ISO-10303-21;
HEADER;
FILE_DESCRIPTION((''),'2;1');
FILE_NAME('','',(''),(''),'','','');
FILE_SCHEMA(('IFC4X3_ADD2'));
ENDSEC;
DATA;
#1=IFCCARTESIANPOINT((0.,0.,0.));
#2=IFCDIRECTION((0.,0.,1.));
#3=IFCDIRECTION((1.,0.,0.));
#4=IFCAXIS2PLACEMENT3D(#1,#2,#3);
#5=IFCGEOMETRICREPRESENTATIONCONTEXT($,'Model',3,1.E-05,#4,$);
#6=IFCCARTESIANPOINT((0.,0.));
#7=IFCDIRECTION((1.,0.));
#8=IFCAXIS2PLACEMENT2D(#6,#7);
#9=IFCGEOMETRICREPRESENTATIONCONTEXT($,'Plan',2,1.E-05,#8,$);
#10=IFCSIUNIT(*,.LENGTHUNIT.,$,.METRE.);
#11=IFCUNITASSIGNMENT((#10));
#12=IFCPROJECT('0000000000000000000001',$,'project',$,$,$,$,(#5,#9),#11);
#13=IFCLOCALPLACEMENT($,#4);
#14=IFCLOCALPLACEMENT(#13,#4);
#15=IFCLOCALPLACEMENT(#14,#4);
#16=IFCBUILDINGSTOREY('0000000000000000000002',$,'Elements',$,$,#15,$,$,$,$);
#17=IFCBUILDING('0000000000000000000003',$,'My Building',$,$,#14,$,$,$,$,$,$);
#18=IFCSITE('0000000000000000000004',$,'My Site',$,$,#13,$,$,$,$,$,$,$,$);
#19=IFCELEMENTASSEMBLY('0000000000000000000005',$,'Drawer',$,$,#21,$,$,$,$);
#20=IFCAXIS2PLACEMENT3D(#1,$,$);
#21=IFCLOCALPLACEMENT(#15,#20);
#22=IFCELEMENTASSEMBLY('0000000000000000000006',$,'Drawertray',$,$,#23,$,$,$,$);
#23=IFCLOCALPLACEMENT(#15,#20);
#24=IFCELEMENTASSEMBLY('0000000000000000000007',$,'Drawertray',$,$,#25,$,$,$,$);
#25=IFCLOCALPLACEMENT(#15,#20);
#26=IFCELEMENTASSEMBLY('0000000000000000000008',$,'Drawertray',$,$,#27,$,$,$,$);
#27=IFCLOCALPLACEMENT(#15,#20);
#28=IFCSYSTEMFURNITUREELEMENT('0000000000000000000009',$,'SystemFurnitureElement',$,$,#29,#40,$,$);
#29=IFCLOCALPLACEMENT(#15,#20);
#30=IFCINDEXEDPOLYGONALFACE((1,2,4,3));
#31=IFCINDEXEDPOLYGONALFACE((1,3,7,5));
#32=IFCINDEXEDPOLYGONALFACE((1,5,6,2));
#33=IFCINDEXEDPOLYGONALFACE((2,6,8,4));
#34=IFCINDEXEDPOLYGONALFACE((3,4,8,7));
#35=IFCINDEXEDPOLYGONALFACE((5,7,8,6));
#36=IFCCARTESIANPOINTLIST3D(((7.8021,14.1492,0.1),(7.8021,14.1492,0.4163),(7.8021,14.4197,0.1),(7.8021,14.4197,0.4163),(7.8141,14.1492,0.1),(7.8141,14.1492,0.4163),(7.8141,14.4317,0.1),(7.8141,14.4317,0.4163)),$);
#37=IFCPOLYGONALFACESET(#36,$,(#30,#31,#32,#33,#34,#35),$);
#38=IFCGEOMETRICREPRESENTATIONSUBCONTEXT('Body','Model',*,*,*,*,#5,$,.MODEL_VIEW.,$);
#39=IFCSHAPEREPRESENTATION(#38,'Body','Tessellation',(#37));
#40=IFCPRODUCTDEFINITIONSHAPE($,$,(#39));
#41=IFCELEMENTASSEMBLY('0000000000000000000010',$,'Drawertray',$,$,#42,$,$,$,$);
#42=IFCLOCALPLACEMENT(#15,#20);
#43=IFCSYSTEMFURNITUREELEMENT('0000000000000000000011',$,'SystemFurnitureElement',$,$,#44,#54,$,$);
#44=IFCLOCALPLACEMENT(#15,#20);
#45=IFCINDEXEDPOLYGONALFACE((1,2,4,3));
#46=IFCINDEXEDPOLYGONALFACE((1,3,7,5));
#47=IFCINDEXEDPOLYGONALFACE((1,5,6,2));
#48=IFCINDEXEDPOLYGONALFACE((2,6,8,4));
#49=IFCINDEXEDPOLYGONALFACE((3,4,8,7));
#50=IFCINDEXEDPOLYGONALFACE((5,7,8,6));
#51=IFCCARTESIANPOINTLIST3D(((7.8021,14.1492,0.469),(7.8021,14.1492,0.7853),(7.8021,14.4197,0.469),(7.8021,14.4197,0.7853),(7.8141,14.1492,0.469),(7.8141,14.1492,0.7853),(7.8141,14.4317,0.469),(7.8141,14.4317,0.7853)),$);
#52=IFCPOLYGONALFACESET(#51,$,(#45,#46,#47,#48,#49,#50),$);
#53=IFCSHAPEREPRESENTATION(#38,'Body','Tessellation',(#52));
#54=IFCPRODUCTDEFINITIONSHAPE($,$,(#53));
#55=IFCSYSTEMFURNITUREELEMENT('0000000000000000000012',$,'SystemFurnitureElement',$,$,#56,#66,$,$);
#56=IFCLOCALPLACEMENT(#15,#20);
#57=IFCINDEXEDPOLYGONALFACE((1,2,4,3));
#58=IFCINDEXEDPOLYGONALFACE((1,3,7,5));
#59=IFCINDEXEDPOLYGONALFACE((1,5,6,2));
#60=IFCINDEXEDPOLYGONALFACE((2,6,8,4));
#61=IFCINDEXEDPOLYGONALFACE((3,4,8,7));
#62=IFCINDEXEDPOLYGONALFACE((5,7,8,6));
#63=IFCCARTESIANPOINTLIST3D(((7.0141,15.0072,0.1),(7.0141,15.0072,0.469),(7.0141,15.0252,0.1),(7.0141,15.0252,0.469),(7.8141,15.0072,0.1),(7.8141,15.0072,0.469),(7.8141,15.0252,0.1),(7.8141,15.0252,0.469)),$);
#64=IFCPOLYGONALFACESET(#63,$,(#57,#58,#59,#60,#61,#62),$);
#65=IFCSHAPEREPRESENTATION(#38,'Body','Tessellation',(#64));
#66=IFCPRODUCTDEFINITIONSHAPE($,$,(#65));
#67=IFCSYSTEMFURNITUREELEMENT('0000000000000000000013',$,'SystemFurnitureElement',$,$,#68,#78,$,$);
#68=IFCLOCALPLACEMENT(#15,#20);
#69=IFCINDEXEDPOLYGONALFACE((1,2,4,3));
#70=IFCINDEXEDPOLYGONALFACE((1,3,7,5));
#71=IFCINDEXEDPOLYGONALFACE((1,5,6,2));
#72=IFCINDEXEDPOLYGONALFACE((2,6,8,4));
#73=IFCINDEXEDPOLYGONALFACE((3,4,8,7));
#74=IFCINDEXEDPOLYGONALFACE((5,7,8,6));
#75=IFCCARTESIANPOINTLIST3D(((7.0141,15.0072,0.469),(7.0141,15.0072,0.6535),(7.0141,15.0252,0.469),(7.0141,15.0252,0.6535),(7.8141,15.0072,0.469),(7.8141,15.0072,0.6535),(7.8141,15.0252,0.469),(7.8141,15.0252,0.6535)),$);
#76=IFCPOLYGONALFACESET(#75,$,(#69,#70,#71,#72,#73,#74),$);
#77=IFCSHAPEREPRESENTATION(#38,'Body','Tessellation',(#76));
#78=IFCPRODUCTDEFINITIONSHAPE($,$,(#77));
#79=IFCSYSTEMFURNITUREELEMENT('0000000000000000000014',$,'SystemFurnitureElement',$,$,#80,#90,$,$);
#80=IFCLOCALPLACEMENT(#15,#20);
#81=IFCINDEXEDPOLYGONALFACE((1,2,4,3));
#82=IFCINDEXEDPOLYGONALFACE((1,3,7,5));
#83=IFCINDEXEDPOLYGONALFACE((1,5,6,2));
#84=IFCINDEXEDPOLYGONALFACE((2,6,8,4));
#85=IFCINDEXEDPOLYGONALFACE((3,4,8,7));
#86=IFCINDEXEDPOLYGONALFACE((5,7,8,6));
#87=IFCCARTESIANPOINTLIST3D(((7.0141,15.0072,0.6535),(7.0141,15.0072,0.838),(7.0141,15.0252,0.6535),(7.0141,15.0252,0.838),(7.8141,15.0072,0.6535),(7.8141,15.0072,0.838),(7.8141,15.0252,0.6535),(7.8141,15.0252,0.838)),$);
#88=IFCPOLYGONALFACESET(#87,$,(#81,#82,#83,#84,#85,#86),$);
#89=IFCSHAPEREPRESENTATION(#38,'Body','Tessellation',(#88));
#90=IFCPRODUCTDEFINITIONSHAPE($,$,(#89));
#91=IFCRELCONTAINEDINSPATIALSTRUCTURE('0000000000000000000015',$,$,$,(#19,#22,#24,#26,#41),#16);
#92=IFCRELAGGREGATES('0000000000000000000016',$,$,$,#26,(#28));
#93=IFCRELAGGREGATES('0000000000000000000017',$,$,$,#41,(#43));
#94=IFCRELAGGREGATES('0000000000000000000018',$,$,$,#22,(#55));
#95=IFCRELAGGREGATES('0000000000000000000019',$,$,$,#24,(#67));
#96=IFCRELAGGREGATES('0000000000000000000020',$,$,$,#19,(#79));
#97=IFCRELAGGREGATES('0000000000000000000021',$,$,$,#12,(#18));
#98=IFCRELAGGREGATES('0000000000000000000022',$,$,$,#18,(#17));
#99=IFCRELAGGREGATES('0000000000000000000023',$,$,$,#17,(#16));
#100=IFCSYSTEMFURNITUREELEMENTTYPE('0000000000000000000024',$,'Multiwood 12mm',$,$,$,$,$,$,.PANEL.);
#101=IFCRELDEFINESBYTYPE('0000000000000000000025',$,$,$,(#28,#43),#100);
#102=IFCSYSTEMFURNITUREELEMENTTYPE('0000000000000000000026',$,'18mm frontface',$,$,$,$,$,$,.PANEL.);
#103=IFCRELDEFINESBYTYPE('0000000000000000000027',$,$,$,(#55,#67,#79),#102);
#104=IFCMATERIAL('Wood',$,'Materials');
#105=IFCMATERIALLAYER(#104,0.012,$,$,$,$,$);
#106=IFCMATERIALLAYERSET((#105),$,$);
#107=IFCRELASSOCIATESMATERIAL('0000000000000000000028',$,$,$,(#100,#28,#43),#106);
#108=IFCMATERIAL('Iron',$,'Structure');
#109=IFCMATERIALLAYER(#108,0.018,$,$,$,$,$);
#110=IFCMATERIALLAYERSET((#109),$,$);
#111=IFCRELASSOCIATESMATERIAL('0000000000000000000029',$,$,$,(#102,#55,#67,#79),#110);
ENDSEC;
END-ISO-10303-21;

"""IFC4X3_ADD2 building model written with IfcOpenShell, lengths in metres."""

from ifc_helpers import new_model, si_unit, frame, origin_with_axes, origin_2d_with_axis, place, context, subcontext, project, spatial, line, indexed_curve, outline, extrude, material, layer, layer_set, layer_usage, type_object, element, aggregate, save


model = new_model("IFC4X3_ADD2")

# Units and contexts
model_context = context("Model", 3, precision=1e-05, world=origin_with_axes())
plan_context = context("Plan", 2, precision=1e-05, world=origin_2d_with_axis())
body_context = subcontext(model_context, "Body", "Model", "MODEL_VIEW")
ifc_project = project(units=[si_unit("LENGTHUNIT", "METRE")], contexts=[model_context, plan_context])

# Site, building, storey
site_placement = place(None, origin_with_axes())
site = spatial("IfcSite", under=ifc_project, at=site_placement, Name="My Site")
building_placement = place(site_placement, origin_with_axes())
building = spatial("IfcBuilding", under=site, at=building_placement, Name="My Building")
storey_placement = place(building_placement, origin_with_axes())
storey = spatial("IfcBuildingStorey", under=building, at=storey_placement, Name="Elements")

# Shared definitions
ifc_material_1 = material(Name="Wood", Category="Materials")
ifc_layer_1 = layer(ifc_material_1, 0.012)
ifc_layer_set_1 = layer_set([ifc_layer_1])
system_furniture_element_type_1 = type_object("IfcSystemFurnitureElementType", Name="Multiwood 12mm", PredefinedType="PANEL", material=ifc_layer_set_1)

# Element assemblies
assembly_1_placement = place(storey_placement, frame((7.8141, 15.0252, 0.6535), z_axis=(0.0, 0.0, 1.0), x_axis=(1.0, 0.0, 0.0)))
assembly_1 = element("IfcElementAssembly", 1, at=assembly_1_placement, inside=storey, Name="Drawer")
assembly_2_placement = place(storey_placement, frame((7.8141, 15.0252, 0.1), z_axis=(0.0, 0.0, 1.0), x_axis=(1.0, 0.0, 0.0)))
assembly_2 = element("IfcElementAssembly", 2, at=assembly_2_placement, inside=storey, Name="Drawertray")
assembly_3_placement = place(storey_placement, frame((7.8141, 15.0252, 0.469), z_axis=(0.0, 0.0, 1.0), x_axis=(1.0, 0.0, 0.0)))
assembly_3 = element("IfcElementAssembly", 3, at=assembly_3_placement, inside=storey, Name="Drawertray")

# Element assemblies, system furniture elements
assembly_4_placement = place(storey_placement, frame((7.0141, 14.1372, 0.1), z_axis=(0.0, 0.0, 1.0), x_axis=(-1.0, 0.0, 0.0)))
assembly_4 = element("IfcElementAssembly", 4, at=assembly_4_placement, inside=storey, Name="Drawertray")
ifc_layer_usage_1 = layer_usage(ifc_layer_set_1, "AXIS2", "POSITIVE", 0.0)
system_furniture_element_1_placement = place(assembly_4_placement, frame((-0.788, -0.2825, 0.0), z_axis=(0.0, 0.0, 1.0), x_axis=(0.000001, 1.0, 0.0)))
system_furniture_element_1 = element("IfcSystemFurnitureElement", 5, at=system_furniture_element_1_placement, type_object=system_furniture_element_type_1, material=ifc_layer_usage_1, Name="SystemFurnitureElement", context=body_context, shape_type="SweptSolid", body=[
    extrude(outline(indexed_curve([(0.0, 0.0), (-0.012, 0.012), (0.2705, 0.012), (0.2705, 0.0)], segments=[line(1, 2, 3, 4, 1)])), origin_with_axes(), (0.0, 0.0, 1.0), 0.3163),
])
assembly_5_placement = place(storey_placement, frame((7.0141, 14.1372, 0.469), z_axis=(0.0, 0.0, 1.0), x_axis=(-1.0, 0.0, 0.0)))
assembly_5 = element("IfcElementAssembly", 6, at=assembly_5_placement, inside=storey, Name="Drawertray")
ifc_layer_usage_2 = layer_usage(ifc_layer_set_1, "AXIS2", "POSITIVE", 0.0)
system_furniture_element_2_placement = place(assembly_5_placement, frame((-0.788, -0.2825, 0.0), z_axis=(0.0, 0.0, 1.0), x_axis=(0.000001, 1.0, 0.0)))
system_furniture_element_2 = element("IfcSystemFurnitureElement", 7, at=system_furniture_element_2_placement, type_object=system_furniture_element_type_1, material=ifc_layer_usage_2, Name="SystemFurnitureElement", context=body_context, shape_type="SweptSolid", body=[
    extrude(outline(indexed_curve([(0.0, 0.0), (-0.012, 0.012), (0.2705, 0.012), (0.2705, 0.0)], segments=[line(1, 2, 3, 4, 1)])), origin_with_axes(), (0.0, 0.0, 1.0), 0.3163),
])

aggregate(assembly_4, [system_furniture_element_1])
aggregate(assembly_5, [system_furniture_element_2])

# System furniture elements
ifc_material_2 = material(Name="Iron", Category="Structure")
ifc_layer_2 = layer(ifc_material_2, 0.018)
ifc_layer_set_2 = layer_set([ifc_layer_2])
ifc_layer_usage_3 = layer_usage(ifc_layer_set_2, "AXIS2", "POSITIVE", 0.0)
system_furniture_element_type_2 = type_object("IfcSystemFurnitureElementType", Name="18mm frontface", PredefinedType="PANEL", material=ifc_layer_set_2)
system_furniture_element_3_placement = place(assembly_2_placement, frame((0.0, 0.0, 0.0), z_axis=(0.0, 0.0, 1.0), x_axis=(-1.0, 0.0, 0.0)))
system_furniture_element_3 = element("IfcSystemFurnitureElement", 8, at=system_furniture_element_3_placement, type_object=system_furniture_element_type_2, material=ifc_layer_usage_3, Name="SystemFurnitureElement", context=body_context, shape_type="SweptSolid", body=[
    extrude(outline(indexed_curve([(0.0, 0.0), (0.0, 0.018), (0.8, 0.018), (0.8, 0.0)], segments=[line(1, 2, 3, 4, 1)])), origin_with_axes(), (0.0, 0.0, 1.0), 0.369),
])
aggregate(assembly_2, [system_furniture_element_3])
ifc_layer_usage_4 = layer_usage(ifc_layer_set_2, "AXIS2", "POSITIVE", 0.0)
system_furniture_element_4_placement = place(assembly_3_placement, frame((0.0, 0.0, 0.0), z_axis=(0.0, 0.0, 1.0), x_axis=(-1.0, 0.0, 0.0)))
system_furniture_element_4 = element("IfcSystemFurnitureElement", 9, at=system_furniture_element_4_placement, type_object=system_furniture_element_type_2, material=ifc_layer_usage_4, Name="SystemFurnitureElement", context=body_context, shape_type="SweptSolid", body=[
    extrude(outline(indexed_curve([(0.0, 0.0), (0.0, 0.018), (0.8, 0.018), (0.8, 0.0)], segments=[line(1, 2, 3, 4, 1)])), origin_with_axes(), (0.0, 0.0, 1.0), 0.1845),
])
aggregate(assembly_3, [system_furniture_element_4])
ifc_layer_usage_5 = layer_usage(ifc_layer_set_2, "AXIS2", "POSITIVE", 0.0)
system_furniture_element_5_placement = place(assembly_1_placement, frame((0.0, 0.0, 0.0), z_axis=(0.0, 0.0, 1.0), x_axis=(-1.0, 0.0, 0.0)))
system_furniture_element_5 = element("IfcSystemFurnitureElement", 10, at=system_furniture_element_5_placement, type_object=system_furniture_element_type_2, material=ifc_layer_usage_5, Name="SystemFurnitureElement", context=body_context, shape_type="SweptSolid", body=[
    extrude(outline(indexed_curve([(0.0, 0.0), (0.0, 0.018), (0.8, 0.018), (0.8, 0.0)], segments=[line(1, 2, 3, 4, 1)])), origin_with_axes(), (0.0, 0.0, 1.0), 0.1845),
])
aggregate(assembly_1, [system_furniture_element_5])

save(model, "model.ifc")
